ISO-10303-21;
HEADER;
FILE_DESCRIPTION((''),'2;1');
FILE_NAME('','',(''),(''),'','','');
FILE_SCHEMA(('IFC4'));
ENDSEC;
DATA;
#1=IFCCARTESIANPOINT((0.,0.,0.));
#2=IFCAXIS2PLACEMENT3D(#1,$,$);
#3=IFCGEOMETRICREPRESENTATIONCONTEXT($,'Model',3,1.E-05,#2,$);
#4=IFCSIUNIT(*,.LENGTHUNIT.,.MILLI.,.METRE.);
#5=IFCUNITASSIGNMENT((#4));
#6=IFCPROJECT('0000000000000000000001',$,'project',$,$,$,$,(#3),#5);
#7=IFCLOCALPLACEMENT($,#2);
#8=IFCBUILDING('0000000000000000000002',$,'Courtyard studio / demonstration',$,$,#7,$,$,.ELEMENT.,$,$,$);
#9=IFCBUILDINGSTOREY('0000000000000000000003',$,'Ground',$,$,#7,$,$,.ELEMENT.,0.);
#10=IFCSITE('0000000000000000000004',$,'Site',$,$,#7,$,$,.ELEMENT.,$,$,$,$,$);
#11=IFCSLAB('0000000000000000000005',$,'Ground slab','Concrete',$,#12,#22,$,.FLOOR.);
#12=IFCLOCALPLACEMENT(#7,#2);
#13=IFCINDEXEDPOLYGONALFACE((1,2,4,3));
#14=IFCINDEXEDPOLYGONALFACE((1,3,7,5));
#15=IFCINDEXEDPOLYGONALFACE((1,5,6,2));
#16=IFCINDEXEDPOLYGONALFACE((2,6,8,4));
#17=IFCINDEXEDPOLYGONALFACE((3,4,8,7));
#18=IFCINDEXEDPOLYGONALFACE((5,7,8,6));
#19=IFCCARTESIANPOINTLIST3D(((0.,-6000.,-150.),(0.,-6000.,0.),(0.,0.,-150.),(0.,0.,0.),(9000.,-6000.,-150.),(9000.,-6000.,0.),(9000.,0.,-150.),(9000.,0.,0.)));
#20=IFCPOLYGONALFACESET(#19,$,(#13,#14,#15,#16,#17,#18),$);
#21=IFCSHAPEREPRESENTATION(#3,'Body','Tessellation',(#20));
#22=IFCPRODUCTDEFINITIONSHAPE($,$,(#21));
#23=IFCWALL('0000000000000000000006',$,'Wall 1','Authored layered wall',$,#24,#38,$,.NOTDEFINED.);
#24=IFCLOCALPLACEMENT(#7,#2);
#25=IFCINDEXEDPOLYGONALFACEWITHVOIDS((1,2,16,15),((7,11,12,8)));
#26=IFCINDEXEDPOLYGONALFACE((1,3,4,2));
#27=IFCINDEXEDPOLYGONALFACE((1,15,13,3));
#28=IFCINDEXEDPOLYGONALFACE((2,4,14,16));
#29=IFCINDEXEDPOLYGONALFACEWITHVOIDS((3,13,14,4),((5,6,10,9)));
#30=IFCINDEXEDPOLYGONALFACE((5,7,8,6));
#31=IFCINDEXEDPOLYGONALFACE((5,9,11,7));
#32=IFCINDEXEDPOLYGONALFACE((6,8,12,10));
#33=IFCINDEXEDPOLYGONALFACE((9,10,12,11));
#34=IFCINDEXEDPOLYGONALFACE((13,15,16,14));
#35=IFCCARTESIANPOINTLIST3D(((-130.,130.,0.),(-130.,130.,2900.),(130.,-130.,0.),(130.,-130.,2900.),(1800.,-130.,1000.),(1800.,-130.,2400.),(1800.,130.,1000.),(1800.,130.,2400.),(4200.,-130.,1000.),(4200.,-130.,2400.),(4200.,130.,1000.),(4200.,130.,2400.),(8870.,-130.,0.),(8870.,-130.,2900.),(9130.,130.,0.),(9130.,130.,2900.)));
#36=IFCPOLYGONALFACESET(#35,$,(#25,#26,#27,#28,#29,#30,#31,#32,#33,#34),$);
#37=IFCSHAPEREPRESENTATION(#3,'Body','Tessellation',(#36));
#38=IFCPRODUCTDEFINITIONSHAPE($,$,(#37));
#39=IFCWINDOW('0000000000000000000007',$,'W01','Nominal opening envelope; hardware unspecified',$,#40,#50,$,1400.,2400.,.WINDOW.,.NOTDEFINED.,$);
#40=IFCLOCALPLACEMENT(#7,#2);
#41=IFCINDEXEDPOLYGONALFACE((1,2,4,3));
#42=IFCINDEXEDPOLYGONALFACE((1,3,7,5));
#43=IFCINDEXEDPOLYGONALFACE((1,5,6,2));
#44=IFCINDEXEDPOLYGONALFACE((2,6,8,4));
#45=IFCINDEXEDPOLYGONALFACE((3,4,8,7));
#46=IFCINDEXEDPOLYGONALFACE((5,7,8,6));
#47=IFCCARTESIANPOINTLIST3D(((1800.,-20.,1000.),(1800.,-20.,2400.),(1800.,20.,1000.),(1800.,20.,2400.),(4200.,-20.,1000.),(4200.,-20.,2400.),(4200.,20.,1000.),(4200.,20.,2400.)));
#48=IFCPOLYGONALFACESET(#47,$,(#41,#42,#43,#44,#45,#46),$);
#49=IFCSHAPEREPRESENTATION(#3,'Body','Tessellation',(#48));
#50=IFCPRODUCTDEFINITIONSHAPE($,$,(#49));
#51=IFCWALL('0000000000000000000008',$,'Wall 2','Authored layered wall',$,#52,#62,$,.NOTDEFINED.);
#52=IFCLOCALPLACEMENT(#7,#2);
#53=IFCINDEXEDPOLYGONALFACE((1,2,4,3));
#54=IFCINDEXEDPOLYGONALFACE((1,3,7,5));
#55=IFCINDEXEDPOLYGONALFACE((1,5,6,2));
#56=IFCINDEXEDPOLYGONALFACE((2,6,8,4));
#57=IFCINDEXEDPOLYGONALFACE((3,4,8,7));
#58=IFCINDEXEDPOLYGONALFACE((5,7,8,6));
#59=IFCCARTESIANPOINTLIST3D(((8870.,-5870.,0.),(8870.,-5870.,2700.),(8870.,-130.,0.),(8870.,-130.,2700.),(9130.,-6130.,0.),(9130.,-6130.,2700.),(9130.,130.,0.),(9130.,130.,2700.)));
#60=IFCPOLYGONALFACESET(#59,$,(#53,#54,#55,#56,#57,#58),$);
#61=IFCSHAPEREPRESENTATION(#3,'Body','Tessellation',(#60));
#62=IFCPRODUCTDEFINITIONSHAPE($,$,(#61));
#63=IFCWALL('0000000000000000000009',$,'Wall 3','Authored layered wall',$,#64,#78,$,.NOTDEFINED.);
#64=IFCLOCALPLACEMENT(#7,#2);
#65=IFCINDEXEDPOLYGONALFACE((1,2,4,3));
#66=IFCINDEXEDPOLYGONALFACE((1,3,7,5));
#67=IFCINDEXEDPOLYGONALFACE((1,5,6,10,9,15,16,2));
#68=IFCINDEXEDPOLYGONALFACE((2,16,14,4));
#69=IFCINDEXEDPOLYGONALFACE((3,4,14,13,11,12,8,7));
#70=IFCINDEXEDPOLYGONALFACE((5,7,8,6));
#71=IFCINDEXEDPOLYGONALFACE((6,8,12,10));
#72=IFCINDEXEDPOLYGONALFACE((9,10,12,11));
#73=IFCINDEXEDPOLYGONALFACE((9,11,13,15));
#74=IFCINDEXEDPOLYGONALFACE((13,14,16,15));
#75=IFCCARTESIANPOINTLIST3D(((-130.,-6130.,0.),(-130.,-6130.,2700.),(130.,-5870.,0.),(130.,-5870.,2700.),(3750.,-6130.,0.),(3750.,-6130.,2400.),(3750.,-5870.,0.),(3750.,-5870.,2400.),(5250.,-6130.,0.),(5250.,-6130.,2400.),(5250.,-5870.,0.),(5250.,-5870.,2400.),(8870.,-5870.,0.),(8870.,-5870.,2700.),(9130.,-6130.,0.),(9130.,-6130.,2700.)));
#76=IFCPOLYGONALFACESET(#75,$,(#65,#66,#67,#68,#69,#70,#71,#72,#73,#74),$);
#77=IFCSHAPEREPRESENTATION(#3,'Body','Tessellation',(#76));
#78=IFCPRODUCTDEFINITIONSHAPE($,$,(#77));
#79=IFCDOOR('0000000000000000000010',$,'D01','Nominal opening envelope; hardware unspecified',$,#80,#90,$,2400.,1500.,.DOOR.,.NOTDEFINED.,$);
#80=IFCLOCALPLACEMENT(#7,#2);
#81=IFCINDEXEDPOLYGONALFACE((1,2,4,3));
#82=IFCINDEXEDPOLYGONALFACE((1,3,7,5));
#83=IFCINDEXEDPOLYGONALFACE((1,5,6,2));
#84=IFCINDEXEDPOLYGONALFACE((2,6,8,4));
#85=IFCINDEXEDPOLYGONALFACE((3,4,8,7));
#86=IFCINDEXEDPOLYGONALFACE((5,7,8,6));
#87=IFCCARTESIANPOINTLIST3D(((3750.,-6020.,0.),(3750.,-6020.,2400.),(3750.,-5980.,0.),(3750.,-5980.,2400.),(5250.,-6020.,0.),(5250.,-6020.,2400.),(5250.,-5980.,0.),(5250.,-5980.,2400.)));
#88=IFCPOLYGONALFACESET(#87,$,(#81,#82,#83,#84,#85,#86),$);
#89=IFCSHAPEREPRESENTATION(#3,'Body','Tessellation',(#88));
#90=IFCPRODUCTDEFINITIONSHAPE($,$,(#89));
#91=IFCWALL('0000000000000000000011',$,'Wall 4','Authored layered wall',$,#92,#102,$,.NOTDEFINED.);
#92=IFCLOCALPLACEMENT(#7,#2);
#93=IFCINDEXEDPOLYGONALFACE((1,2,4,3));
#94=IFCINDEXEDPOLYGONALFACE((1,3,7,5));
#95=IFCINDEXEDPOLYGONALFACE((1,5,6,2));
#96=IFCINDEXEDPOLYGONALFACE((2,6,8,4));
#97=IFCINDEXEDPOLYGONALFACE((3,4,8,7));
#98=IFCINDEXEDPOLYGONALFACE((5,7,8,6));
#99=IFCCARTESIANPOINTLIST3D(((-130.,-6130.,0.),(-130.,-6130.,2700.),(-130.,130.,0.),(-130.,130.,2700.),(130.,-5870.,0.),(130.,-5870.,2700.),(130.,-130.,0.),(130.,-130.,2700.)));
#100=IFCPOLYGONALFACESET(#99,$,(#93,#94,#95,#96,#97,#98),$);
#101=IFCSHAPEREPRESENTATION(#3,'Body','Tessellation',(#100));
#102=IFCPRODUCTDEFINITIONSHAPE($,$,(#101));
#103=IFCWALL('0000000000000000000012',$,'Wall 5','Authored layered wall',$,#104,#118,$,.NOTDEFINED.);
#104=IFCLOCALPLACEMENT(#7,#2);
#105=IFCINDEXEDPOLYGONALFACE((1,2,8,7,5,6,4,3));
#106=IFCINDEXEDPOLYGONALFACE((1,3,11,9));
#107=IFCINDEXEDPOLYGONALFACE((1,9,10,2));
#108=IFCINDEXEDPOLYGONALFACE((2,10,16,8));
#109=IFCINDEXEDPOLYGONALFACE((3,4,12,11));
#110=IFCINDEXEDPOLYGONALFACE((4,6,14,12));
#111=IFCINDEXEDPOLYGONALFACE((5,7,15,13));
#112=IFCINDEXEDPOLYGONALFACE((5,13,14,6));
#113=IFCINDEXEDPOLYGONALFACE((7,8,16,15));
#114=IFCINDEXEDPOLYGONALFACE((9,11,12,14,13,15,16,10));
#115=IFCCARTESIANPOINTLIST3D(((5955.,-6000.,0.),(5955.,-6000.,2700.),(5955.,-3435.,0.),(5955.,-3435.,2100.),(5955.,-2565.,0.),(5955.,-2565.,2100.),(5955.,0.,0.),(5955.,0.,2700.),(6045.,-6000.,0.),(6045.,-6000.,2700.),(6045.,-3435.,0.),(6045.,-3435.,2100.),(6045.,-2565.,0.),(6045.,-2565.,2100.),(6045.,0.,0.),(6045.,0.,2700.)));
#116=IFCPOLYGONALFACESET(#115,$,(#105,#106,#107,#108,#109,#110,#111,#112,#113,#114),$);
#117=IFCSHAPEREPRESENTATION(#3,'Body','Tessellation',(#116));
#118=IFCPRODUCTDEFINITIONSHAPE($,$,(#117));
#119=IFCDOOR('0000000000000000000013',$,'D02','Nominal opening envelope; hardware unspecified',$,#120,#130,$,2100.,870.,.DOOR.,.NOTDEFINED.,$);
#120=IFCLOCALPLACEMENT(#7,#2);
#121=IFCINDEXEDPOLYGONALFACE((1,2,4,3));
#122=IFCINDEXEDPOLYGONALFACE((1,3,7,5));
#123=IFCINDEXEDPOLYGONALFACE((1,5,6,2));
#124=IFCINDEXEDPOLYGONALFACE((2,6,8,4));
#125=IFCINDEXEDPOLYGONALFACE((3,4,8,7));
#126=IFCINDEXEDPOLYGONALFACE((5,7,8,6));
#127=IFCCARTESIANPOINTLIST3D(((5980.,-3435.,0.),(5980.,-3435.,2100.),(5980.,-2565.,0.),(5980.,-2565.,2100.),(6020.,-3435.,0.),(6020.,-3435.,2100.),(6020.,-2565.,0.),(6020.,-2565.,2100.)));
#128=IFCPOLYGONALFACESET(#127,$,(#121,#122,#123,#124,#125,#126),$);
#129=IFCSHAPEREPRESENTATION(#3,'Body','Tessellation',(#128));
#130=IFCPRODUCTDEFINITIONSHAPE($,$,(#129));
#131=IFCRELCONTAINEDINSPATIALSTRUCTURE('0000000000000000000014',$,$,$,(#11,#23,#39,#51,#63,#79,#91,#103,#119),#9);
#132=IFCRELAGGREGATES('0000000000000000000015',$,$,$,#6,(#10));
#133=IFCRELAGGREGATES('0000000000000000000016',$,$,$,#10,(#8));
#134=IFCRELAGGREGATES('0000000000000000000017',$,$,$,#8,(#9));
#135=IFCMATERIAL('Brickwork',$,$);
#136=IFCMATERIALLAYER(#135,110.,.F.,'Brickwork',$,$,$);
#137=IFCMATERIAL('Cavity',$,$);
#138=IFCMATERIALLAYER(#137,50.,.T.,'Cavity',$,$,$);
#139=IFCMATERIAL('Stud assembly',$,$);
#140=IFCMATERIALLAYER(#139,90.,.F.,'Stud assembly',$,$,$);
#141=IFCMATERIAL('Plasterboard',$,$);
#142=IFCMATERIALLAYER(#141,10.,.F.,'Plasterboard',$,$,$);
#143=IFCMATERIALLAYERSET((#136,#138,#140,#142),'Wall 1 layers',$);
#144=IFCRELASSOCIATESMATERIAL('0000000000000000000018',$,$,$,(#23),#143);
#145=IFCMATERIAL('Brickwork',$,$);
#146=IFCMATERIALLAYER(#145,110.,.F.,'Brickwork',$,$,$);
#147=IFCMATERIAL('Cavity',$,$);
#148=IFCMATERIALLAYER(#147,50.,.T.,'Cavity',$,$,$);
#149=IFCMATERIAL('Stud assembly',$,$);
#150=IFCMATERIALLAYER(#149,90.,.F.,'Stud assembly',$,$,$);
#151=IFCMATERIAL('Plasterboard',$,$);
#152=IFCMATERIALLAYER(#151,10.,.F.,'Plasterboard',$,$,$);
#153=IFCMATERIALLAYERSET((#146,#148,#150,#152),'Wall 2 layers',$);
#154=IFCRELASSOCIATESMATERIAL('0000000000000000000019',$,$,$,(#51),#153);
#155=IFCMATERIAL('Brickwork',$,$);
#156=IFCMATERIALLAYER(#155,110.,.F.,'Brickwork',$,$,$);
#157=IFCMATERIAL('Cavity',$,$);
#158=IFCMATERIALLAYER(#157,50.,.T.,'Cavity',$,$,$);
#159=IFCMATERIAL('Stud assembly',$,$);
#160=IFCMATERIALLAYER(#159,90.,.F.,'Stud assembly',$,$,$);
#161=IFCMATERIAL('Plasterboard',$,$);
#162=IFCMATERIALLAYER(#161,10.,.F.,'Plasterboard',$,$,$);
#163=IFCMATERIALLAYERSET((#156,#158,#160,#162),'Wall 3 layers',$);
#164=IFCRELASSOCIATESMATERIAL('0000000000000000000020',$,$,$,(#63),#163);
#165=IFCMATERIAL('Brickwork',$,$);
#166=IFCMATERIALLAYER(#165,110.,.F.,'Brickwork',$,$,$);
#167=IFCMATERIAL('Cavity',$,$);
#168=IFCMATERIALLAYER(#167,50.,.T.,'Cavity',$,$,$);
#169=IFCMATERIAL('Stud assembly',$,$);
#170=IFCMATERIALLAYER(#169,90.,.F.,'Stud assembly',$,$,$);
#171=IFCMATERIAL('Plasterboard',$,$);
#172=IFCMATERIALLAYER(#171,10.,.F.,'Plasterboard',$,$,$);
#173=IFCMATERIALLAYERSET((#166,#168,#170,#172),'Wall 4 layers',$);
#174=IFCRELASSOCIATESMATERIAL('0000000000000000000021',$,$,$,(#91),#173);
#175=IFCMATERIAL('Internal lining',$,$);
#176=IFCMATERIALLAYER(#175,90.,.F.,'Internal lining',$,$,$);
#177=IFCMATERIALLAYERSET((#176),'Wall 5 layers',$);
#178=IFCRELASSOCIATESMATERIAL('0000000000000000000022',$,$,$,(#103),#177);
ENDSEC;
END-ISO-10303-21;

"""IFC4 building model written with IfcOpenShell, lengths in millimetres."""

from ifc_helpers import new_model, si_unit, frame, origin, place, context, project, spatial, polyline, outline, extrude, material, layer, layer_set, layer_usage, element, fill, save


model = new_model("IFC4")

# Units and contexts
model_context = context("Model", 3, precision=1e-05, world=origin())
ifc_project = project(units=[si_unit("LENGTHUNIT", "METRE", prefix="MILLI")], contexts=[model_context])

# Site, building, storey
placement = place(None, origin())
site = spatial("IfcSite", under=ifc_project, at=placement, Name="Site", CompositionType="ELEMENT")
building = spatial("IfcBuilding", under=site, at=placement, Name="Courtyard studio / demonstration", CompositionType="ELEMENT")
storey = spatial("IfcBuildingStorey", under=building, at=placement, Name="Ground", CompositionType="ELEMENT", Elevation=0.0)

# Slab
element("IfcSlab", 1, at=placement, inside=storey, Name="Ground slab", Description="Concrete", PredefinedType="FLOOR", context=model_context, shape_type="SweptSolid", body=[
    extrude(outline(polyline([(0.0, 0.0), (9000.0, 0.0), (9000.0, -6000.0), (0.0, -6000.0), (0.0, 0.0)])), frame((0.0, 0.0, -150.0)), (0.0, 0.0, 1.0), 150.0),
])

# Wall, opening, window
ifc_material_1 = material(Name="Brickwork")
ifc_layer_1 = layer(ifc_material_1, 110.0, ventilated=False, Name="Brickwork")
ifc_material_2 = material(Name="Cavity")
ifc_layer_2 = layer(ifc_material_2, 50.0, ventilated=True, Name="Cavity")
ifc_material_3 = material(Name="Stud assembly")
ifc_layer_3 = layer(ifc_material_3, 90.0, ventilated=False, Name="Stud assembly")
ifc_material_4 = material(Name="Plasterboard")
ifc_layer_4 = layer(ifc_material_4, 10.0, ventilated=False, Name="Plasterboard")
ifc_layer_set_1 = layer_set([ifc_layer_1, ifc_layer_2, ifc_layer_3, ifc_layer_4], Name="Wall 1 layers")
ifc_layer_usage_1 = layer_usage(ifc_layer_set_1, "AXIS2", "POSITIVE", -130.0)
wall_1 = element("IfcWall", 2, at=placement, inside=storey, material=ifc_layer_usage_1, Name="Wall 1", Description="Authored layered wall", PredefinedType="NOTDEFINED", context=model_context, shape_type="SweptSolid", body=[
    extrude(outline(polyline([(-130.0, 130.0), (9130.0, 130.0), (8870.0, -130.0), (130.0, -130.0), (-130.0, 130.0)])), origin(), (0.0, 0.0, 1.0), 2900.0),
])
opening_1 = element("IfcOpeningElement", 3, at=placement, cuts=wall_1, PredefinedType="OPENING", context=model_context, shape_type="SweptSolid", body=[
    extrude(outline(polyline([(1800.0, 131.0), (4200.0, 131.0), (4200.0, -131.0), (1800.0, -131.0), (1800.0, 131.0)])), frame((0.0, 0.0, 1000.0)), (0.0, 0.0, 1.0), 1400.0),
])
window = element("IfcWindow", 4, at=placement, inside=storey, Name="W01", Description="Nominal opening envelope; hardware unspecified", OverallHeight=1400.0, OverallWidth=2400.0, PartitioningType="NOTDEFINED", PredefinedType="WINDOW", context=model_context, shape_type="SweptSolid", body=[
    extrude(outline(polyline([(1800.0, 20.0), (4200.0, 20.0), (4200.0, -20.0), (1800.0, -20.0), (1800.0, 20.0)])), frame((0.0, 0.0, 1000.0)), (0.0, 0.0, 1.0), 1400.0),
])
fill(opening_1, window)

# Wall
ifc_material_5 = material(Name="Brickwork")
ifc_layer_5 = layer(ifc_material_5, 110.0, ventilated=False, Name="Brickwork")
ifc_material_6 = material(Name="Cavity")
ifc_layer_6 = layer(ifc_material_6, 50.0, ventilated=True, Name="Cavity")
ifc_material_7 = material(Name="Stud assembly")
ifc_layer_7 = layer(ifc_material_7, 90.0, ventilated=False, Name="Stud assembly")
ifc_material_8 = material(Name="Plasterboard")
ifc_layer_8 = layer(ifc_material_8, 10.0, ventilated=False, Name="Plasterboard")
ifc_layer_set_2 = layer_set([ifc_layer_5, ifc_layer_6, ifc_layer_7, ifc_layer_8], Name="Wall 2 layers")
ifc_layer_usage_2 = layer_usage(ifc_layer_set_2, "AXIS2", "POSITIVE", -130.0)
element("IfcWall", 5, at=placement, inside=storey, material=ifc_layer_usage_2, Name="Wall 2", Description="Authored layered wall", PredefinedType="NOTDEFINED", context=model_context, shape_type="SweptSolid", body=[
    extrude(outline(polyline([(9130.0, 130.0), (9130.0, -6130.0), (8870.0, -5870.0), (8870.0, -130.0), (9130.0, 130.0)])), origin(), (0.0, 0.0, 1.0), 2700.0),
])

# Wall, opening, door
ifc_material_9 = material(Name="Brickwork")
ifc_layer_9 = layer(ifc_material_9, 110.0, ventilated=False, Name="Brickwork")
ifc_material_10 = material(Name="Cavity")
ifc_layer_10 = layer(ifc_material_10, 50.0, ventilated=True, Name="Cavity")
ifc_material_11 = material(Name="Stud assembly")
ifc_layer_11 = layer(ifc_material_11, 90.0, ventilated=False, Name="Stud assembly")
ifc_material_12 = material(Name="Plasterboard")
ifc_layer_12 = layer(ifc_material_12, 10.0, ventilated=False, Name="Plasterboard")
ifc_layer_set_3 = layer_set([ifc_layer_9, ifc_layer_10, ifc_layer_11, ifc_layer_12], Name="Wall 3 layers")
ifc_layer_usage_3 = layer_usage(ifc_layer_set_3, "AXIS2", "POSITIVE", -130.0)
wall_2 = element("IfcWall", 6, at=placement, inside=storey, material=ifc_layer_usage_3, Name="Wall 3", Description="Authored layered wall", PredefinedType="NOTDEFINED", context=model_context, shape_type="SweptSolid", body=[
    extrude(outline(polyline([(9130.0, -6130.0), (-130.0, -6130.0), (130.0, -5870.0), (8870.0, -5870.0), (9130.0, -6130.0)])), origin(), (0.0, 0.0, 1.0), 2700.0),
])
opening_2 = element("IfcOpeningElement", 7, at=placement, cuts=wall_2, PredefinedType="OPENING", context=model_context, shape_type="SweptSolid", body=[
    extrude(outline(polyline([(5250.0, -6131.0), (3750.0, -6131.0), (3750.0, -5869.0), (5250.0, -5869.0), (5250.0, -6131.0)])), origin(), (0.0, 0.0, 1.0), 2400.0),
])
door_1 = element("IfcDoor", 8, at=placement, inside=storey, Name="D01", Description="Nominal opening envelope; hardware unspecified", OperationType="NOTDEFINED", OverallHeight=2400.0, OverallWidth=1500.0, PredefinedType="DOOR", context=model_context, shape_type="SweptSolid", body=[
    extrude(outline(polyline([(5250.0, -6020.0), (3750.0, -6020.0), (3750.0, -5980.0), (5250.0, -5980.0), (5250.0, -6020.0)])), origin(), (0.0, 0.0, 1.0), 2400.0),
])
fill(opening_2, door_1)

# Wall
ifc_material_13 = material(Name="Brickwork")
ifc_layer_13 = layer(ifc_material_13, 110.0, ventilated=False, Name="Brickwork")
ifc_material_14 = material(Name="Cavity")
ifc_layer_14 = layer(ifc_material_14, 50.0, ventilated=True, Name="Cavity")
ifc_material_15 = material(Name="Stud assembly")
ifc_layer_15 = layer(ifc_material_15, 90.0, ventilated=False, Name="Stud assembly")
ifc_material_16 = material(Name="Plasterboard")
ifc_layer_16 = layer(ifc_material_16, 10.0, ventilated=False, Name="Plasterboard")
ifc_layer_set_4 = layer_set([ifc_layer_13, ifc_layer_14, ifc_layer_15, ifc_layer_16], Name="Wall 4 layers")
ifc_layer_usage_4 = layer_usage(ifc_layer_set_4, "AXIS2", "POSITIVE", -130.0)
element("IfcWall", 9, at=placement, inside=storey, material=ifc_layer_usage_4, Name="Wall 4", Description="Authored layered wall", PredefinedType="NOTDEFINED", context=model_context, shape_type="SweptSolid", body=[
    extrude(outline(polyline([(-130.0, -6130.0), (-130.0, 130.0), (130.0, -130.0), (130.0, -5870.0), (-130.0, -6130.0)])), origin(), (0.0, 0.0, 1.0), 2700.0),
])

# Wall, opening, door
ifc_material_17 = material(Name="Internal lining")
ifc_layer_17 = layer(ifc_material_17, 90.0, ventilated=False, Name="Internal lining")
ifc_layer_set_5 = layer_set([ifc_layer_17], Name="Wall 5 layers")
ifc_layer_usage_5 = layer_usage(ifc_layer_set_5, "AXIS2", "POSITIVE", -45.0)
wall_3 = element("IfcWall", 10, at=placement, inside=storey, material=ifc_layer_usage_5, Name="Wall 5", Description="Authored layered wall", PredefinedType="NOTDEFINED", context=model_context, shape_type="SweptSolid", body=[
    extrude(outline(polyline([(6045.0, 0.0), (6045.0, -6000.0), (5955.0, -6000.0), (5955.0, 0.0), (6045.0, 0.0)])), origin(), (0.0, 0.0, 1.0), 2700.0),
])
opening_3 = element("IfcOpeningElement", 11, at=placement, cuts=wall_3, PredefinedType="OPENING", context=model_context, shape_type="SweptSolid", body=[
    extrude(outline(polyline([(6046.0, -2565.0), (6046.0, -3435.0), (5954.0, -3435.0), (5954.0, -2565.0), (6046.0, -2565.0)])), origin(), (0.0, 0.0, 1.0), 2100.0),
])
door_2 = element("IfcDoor", 12, at=placement, inside=storey, Name="D02", Description="Nominal opening envelope; hardware unspecified", OperationType="NOTDEFINED", OverallHeight=2100.0, OverallWidth=870.0, PredefinedType="DOOR", context=model_context, shape_type="SweptSolid", body=[
    extrude(outline(polyline([(6020.0, -2565.0), (6020.0, -3435.0), (5980.0, -3435.0), (5980.0, -2565.0), (6020.0, -2565.0)])), origin(), (0.0, 0.0, 1.0), 2100.0),
])
fill(opening_3, door_2)

save(model, "model.ifc")
